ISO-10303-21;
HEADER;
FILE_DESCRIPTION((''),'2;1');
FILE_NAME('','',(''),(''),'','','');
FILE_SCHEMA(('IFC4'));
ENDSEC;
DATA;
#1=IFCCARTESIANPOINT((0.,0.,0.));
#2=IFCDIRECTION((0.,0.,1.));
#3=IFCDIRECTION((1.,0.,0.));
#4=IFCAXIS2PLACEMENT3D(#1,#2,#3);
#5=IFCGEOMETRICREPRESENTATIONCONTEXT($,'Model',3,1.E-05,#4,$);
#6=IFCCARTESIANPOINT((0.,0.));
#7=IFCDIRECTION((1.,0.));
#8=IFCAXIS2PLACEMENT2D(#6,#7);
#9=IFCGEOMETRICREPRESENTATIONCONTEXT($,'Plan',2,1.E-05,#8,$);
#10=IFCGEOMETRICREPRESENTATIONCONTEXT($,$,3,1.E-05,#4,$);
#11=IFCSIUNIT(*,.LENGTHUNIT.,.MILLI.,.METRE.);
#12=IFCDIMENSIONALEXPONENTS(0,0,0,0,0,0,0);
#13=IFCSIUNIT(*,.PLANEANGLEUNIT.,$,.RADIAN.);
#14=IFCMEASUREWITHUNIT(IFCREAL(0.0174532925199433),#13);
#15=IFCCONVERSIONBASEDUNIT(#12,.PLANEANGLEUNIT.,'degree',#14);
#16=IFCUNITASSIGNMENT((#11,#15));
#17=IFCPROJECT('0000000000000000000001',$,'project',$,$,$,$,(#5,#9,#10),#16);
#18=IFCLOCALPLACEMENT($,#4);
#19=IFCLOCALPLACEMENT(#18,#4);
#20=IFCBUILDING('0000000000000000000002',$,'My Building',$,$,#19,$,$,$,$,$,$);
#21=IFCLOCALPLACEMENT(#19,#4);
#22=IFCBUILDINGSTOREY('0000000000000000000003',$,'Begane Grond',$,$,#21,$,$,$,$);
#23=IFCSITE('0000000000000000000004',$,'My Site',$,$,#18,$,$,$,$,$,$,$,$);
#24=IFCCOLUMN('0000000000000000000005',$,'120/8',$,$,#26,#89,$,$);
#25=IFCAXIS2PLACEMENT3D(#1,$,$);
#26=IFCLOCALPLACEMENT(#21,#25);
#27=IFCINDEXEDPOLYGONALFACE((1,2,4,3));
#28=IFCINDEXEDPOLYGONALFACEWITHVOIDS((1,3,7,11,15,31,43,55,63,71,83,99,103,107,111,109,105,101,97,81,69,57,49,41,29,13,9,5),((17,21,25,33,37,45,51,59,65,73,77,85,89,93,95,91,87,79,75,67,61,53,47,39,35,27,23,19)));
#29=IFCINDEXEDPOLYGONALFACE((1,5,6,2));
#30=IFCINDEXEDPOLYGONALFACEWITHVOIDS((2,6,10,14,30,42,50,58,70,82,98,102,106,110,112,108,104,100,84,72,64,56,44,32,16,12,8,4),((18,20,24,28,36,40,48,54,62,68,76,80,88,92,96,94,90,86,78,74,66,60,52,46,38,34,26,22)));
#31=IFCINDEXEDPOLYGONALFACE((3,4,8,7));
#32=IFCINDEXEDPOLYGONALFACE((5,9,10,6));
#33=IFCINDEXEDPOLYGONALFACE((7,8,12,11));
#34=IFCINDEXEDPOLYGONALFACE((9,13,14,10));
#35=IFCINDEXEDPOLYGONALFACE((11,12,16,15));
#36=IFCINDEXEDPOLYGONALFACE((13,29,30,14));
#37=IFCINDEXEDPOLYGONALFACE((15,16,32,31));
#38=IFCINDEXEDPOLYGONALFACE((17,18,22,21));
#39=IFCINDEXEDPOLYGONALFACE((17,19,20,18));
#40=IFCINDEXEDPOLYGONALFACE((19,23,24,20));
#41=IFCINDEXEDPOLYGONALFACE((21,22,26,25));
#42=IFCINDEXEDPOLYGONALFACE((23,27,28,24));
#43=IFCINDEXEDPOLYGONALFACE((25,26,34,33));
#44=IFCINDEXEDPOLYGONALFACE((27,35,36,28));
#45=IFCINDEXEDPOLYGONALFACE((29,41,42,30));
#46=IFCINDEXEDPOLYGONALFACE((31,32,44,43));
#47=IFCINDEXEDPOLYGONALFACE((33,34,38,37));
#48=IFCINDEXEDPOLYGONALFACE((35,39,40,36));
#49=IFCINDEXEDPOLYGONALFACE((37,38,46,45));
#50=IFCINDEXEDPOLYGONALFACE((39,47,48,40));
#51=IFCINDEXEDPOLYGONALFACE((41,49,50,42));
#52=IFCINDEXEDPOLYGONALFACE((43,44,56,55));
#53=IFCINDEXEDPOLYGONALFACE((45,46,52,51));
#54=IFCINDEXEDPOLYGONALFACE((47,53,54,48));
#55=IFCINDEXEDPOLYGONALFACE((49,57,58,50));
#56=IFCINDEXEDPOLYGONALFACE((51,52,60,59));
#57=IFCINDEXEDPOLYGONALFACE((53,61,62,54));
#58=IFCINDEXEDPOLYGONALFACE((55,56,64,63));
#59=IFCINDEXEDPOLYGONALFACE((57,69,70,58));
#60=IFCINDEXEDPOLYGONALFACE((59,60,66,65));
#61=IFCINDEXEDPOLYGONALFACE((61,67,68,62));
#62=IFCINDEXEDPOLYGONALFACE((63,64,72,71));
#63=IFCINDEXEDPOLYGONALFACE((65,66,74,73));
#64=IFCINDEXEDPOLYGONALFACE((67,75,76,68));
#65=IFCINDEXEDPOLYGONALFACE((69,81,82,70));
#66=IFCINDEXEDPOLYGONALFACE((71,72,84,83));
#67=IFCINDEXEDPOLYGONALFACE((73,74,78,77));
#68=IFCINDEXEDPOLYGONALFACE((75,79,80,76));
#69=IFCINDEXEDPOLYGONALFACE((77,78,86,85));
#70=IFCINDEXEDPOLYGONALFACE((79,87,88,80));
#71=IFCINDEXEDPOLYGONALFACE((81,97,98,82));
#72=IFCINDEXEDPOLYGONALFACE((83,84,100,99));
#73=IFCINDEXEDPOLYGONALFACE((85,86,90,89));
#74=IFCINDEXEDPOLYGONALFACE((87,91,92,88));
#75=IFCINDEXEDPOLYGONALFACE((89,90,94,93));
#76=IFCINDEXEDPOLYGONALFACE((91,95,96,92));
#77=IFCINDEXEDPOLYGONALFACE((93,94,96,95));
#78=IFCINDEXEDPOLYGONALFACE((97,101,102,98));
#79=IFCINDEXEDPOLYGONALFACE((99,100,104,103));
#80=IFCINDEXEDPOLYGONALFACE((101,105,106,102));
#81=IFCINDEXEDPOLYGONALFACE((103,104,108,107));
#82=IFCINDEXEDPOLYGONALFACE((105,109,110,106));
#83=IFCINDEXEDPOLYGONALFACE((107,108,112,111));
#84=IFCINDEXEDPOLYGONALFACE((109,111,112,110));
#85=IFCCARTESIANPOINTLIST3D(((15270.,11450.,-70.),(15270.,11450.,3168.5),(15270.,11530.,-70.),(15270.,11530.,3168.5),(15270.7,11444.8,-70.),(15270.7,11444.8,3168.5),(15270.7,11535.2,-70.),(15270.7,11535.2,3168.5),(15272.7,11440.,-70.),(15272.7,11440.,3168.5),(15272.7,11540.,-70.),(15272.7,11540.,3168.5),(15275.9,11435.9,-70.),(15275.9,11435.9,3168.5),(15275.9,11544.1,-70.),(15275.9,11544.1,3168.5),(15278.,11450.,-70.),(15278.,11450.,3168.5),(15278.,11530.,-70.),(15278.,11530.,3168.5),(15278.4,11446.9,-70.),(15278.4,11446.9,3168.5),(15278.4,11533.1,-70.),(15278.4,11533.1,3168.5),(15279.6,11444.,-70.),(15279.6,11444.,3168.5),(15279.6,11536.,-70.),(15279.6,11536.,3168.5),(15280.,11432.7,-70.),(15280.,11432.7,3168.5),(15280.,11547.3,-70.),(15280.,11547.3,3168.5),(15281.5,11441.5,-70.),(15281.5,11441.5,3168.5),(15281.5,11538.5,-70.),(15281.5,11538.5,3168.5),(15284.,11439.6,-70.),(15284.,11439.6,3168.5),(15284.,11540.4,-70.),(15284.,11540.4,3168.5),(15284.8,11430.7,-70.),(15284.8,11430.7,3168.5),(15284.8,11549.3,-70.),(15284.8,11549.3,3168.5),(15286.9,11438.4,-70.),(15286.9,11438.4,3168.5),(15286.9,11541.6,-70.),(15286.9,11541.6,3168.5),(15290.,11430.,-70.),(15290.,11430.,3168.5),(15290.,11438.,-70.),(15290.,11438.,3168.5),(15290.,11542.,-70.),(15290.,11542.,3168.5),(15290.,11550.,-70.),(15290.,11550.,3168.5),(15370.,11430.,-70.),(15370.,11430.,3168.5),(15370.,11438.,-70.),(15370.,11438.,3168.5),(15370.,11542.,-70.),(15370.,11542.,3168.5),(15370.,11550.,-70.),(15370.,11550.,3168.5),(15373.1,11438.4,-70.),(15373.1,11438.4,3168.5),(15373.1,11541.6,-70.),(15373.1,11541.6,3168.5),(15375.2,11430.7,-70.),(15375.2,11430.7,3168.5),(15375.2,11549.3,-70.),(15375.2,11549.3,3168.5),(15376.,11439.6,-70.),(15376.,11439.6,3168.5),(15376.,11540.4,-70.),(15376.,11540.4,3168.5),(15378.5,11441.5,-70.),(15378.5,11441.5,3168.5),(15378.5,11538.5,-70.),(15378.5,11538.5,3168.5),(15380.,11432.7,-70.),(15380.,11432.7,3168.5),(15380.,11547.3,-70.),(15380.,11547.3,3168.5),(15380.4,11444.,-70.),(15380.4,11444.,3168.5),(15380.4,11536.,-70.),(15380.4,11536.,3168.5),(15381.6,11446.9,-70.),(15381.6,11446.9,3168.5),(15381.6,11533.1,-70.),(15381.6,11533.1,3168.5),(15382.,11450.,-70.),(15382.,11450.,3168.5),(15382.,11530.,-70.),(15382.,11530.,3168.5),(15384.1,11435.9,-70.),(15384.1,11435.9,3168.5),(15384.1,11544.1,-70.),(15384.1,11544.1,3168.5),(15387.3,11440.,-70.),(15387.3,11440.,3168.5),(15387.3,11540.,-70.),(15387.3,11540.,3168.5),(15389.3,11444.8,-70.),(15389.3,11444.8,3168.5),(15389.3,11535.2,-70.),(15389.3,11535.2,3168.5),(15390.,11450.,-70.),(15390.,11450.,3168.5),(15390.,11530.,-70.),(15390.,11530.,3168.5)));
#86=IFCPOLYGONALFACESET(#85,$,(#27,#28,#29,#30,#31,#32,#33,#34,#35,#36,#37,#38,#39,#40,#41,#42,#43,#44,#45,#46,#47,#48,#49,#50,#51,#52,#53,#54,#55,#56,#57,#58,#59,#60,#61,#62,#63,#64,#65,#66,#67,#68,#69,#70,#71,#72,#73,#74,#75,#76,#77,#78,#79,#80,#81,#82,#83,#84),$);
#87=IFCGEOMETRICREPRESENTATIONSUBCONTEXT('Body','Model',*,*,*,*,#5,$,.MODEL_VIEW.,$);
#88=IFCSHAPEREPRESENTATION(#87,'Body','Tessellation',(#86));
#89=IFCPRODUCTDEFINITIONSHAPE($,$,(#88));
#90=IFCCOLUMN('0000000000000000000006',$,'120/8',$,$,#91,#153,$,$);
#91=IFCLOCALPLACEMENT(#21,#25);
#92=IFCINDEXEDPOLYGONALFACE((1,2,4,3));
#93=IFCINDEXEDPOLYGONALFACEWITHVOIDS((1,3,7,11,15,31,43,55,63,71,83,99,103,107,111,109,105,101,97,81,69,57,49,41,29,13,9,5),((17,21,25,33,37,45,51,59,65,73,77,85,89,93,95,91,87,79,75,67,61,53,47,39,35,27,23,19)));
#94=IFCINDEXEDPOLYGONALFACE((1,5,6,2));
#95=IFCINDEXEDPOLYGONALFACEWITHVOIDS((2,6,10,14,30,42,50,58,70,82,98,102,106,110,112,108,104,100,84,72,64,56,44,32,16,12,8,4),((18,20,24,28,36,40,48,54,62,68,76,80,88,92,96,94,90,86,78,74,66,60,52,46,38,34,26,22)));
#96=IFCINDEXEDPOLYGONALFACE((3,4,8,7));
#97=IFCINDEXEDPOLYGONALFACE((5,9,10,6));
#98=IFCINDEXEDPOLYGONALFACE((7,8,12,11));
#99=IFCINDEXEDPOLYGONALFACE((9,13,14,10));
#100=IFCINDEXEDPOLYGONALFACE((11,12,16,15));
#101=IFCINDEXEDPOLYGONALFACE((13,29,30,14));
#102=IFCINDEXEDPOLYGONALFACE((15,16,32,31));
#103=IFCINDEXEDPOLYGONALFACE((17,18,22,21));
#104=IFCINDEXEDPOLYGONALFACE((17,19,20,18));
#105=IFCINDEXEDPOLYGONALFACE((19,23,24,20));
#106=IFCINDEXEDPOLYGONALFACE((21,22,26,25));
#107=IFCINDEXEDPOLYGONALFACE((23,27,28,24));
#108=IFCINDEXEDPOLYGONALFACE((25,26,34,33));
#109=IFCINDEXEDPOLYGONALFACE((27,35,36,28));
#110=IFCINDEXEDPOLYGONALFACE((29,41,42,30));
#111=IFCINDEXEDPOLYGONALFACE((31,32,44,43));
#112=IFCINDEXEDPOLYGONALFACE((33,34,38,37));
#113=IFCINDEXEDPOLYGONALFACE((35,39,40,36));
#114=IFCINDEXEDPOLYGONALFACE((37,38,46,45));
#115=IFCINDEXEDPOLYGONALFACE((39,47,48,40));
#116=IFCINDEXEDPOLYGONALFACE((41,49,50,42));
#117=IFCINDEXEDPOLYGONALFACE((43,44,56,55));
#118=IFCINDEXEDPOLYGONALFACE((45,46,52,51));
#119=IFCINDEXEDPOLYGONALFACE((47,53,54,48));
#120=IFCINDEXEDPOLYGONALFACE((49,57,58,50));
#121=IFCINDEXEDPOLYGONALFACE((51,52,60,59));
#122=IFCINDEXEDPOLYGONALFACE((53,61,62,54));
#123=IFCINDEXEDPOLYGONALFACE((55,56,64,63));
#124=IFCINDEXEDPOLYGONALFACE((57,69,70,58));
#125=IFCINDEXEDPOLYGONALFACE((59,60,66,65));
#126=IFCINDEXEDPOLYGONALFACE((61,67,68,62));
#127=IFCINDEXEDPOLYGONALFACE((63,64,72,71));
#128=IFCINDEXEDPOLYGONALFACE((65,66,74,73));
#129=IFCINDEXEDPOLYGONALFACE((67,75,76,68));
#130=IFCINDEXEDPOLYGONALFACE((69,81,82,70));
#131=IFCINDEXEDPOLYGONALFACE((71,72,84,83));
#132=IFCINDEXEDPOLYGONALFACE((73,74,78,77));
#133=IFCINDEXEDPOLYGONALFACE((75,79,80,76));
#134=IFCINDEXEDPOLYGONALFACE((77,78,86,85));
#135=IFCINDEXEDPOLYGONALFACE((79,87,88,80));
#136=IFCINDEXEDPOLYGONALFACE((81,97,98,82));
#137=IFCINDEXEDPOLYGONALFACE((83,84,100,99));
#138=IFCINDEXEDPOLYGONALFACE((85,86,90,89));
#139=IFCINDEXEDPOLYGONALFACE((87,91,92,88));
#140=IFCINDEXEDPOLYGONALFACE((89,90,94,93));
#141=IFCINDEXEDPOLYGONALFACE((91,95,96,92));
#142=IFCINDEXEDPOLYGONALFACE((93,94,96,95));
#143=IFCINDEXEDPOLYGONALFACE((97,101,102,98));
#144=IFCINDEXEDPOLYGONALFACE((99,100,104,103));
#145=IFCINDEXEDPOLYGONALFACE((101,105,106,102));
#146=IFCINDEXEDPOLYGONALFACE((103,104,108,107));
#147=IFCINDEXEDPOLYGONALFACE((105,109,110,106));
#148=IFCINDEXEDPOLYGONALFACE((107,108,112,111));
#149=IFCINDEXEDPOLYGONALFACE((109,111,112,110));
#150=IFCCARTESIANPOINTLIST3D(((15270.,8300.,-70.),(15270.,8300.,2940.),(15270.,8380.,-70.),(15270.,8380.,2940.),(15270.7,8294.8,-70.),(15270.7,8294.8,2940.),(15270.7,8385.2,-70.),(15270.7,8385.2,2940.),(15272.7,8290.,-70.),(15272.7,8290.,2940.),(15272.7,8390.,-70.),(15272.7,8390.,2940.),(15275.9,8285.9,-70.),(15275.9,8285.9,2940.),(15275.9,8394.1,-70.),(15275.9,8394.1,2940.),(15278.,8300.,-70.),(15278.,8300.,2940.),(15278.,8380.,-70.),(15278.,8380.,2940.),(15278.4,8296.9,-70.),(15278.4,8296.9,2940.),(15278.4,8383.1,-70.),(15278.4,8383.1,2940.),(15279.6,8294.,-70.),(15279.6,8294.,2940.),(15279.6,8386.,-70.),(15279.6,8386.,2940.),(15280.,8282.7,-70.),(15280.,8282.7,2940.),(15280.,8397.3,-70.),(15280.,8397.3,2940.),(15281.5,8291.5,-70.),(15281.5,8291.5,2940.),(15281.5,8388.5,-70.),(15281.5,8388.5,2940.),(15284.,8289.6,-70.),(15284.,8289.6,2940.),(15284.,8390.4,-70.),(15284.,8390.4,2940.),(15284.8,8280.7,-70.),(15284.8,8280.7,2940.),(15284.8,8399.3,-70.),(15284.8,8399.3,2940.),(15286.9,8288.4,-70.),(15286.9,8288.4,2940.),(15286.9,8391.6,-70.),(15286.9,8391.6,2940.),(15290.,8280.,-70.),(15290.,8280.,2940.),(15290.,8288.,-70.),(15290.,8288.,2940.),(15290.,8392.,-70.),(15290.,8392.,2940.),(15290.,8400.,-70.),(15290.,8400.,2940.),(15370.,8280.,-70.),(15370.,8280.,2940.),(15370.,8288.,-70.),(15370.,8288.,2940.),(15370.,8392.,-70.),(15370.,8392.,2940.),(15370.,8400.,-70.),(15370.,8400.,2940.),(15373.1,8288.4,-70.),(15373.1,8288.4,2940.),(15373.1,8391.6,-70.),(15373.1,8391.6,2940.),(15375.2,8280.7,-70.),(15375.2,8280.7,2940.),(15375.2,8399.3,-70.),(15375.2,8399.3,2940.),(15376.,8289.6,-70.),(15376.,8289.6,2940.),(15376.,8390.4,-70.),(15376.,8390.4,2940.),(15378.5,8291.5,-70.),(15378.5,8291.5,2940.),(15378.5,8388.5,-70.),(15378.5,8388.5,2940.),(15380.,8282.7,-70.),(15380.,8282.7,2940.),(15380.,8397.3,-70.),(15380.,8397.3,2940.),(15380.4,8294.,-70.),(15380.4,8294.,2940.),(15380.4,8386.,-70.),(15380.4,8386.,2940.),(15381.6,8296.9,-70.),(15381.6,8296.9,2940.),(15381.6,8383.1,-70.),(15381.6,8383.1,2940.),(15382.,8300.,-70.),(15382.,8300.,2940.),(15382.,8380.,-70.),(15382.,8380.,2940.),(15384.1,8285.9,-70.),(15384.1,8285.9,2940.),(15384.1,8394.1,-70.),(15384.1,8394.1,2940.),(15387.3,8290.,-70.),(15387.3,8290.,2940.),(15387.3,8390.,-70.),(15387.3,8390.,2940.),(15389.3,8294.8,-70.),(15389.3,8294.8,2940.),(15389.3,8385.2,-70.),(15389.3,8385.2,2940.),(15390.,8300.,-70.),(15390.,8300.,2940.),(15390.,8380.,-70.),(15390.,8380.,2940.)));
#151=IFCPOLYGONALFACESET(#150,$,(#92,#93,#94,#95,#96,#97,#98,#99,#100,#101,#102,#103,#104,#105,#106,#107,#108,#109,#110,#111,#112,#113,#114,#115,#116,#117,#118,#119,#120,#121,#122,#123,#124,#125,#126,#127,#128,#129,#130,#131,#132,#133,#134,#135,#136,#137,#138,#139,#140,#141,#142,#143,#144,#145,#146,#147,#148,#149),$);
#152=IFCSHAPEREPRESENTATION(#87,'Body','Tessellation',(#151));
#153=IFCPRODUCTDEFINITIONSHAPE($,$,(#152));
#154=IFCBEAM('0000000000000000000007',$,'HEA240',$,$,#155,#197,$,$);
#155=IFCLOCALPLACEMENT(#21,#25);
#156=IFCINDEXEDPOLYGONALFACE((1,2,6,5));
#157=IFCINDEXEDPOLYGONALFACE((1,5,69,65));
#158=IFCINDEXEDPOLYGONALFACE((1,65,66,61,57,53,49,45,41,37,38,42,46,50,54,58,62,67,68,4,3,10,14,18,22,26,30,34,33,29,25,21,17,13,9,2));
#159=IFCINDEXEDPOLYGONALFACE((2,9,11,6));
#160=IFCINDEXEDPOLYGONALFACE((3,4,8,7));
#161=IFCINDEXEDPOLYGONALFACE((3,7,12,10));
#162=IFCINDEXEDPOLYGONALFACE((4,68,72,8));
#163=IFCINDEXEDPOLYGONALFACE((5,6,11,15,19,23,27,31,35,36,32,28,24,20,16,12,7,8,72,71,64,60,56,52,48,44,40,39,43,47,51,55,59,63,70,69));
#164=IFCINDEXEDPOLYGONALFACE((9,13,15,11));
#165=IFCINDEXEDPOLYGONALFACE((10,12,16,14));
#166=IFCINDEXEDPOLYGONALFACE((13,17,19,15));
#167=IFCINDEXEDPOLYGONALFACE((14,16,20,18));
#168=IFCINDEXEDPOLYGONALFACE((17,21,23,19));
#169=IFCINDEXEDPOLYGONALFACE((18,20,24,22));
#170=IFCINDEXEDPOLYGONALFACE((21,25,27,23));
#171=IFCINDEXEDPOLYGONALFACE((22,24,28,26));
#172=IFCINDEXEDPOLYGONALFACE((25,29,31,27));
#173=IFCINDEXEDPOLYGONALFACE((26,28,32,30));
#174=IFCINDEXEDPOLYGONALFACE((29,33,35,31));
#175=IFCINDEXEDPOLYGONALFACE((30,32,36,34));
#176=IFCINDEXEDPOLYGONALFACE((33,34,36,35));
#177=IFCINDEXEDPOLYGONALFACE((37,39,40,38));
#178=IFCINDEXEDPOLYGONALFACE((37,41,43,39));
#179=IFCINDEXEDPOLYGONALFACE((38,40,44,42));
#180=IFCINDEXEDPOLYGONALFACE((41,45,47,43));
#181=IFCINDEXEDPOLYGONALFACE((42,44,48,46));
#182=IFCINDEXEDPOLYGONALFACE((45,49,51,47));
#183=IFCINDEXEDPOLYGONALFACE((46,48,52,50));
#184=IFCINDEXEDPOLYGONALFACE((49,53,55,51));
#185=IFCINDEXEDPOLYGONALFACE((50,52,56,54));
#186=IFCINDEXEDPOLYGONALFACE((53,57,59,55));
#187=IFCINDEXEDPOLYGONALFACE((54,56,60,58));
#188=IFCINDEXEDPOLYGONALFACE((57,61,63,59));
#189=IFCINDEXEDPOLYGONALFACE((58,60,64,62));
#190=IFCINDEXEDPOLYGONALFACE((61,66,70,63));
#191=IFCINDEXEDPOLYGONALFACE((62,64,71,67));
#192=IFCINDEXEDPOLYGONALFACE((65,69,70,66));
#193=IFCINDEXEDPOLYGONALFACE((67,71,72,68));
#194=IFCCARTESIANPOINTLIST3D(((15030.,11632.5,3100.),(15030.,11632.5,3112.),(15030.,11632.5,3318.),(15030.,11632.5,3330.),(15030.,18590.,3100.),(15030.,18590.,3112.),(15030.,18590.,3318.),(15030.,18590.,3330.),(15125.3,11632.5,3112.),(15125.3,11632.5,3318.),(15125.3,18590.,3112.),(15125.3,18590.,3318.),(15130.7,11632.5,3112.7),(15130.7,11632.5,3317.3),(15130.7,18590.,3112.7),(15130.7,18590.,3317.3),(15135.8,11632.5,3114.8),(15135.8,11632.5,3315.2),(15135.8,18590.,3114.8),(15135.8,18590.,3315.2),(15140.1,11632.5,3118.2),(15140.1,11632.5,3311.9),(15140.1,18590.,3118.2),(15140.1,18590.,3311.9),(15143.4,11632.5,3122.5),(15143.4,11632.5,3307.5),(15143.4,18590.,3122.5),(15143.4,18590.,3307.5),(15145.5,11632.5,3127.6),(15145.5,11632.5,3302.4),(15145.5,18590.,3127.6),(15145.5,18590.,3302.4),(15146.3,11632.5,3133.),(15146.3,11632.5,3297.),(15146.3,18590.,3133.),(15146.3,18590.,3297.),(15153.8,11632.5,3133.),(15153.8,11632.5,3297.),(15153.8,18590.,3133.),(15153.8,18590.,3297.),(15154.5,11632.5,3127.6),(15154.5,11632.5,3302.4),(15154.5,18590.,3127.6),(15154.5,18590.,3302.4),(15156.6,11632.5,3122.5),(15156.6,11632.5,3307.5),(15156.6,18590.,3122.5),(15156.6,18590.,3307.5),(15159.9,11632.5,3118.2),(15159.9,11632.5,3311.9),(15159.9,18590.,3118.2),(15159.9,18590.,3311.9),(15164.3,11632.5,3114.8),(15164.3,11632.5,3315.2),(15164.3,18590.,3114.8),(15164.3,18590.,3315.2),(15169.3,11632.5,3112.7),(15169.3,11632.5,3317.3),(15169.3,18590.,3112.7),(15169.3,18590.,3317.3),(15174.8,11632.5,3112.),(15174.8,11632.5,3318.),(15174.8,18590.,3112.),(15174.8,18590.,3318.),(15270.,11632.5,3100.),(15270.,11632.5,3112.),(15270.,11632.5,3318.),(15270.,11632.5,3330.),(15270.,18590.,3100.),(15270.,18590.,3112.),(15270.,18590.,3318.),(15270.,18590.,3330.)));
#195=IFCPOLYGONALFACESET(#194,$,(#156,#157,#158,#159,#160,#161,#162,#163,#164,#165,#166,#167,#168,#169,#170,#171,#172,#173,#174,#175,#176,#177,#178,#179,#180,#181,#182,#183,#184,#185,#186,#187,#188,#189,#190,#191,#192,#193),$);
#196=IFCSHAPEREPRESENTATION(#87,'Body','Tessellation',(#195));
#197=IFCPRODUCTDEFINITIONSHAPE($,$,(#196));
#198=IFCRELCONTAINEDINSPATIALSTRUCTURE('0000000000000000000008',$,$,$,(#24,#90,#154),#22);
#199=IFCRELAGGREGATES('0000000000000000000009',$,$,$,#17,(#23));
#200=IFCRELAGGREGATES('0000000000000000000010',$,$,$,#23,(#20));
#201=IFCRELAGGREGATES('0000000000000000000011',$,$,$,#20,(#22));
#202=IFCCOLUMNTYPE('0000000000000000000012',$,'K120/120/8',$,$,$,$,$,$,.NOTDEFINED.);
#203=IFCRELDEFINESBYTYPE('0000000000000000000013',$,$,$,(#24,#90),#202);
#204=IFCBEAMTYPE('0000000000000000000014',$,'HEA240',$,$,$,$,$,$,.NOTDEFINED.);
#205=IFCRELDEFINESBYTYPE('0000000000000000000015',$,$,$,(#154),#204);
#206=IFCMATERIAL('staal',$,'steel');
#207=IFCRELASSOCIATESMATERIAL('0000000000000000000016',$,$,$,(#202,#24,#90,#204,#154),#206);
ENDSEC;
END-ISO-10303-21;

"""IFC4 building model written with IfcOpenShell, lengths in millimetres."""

from ifc_helpers import new_model, entity, si_unit, converted_unit, frame, origin_with_axes, origin_2d_with_axis, place, context, subcontext, project, spatial, hollow_rectangle, i_section, extrude, material, material_profile, profile_set, profile_usage, type_object, element, save


model = new_model("IFC4")

# Units and contexts
model_context = context("Model", 3, precision=1e-05, world=origin_with_axes())
plan_context = context("Plan", 2, precision=1e-05, world=origin_2d_with_axis())
context_of_model = context(None, 3, precision=1e-05, world=origin_with_axes())
body_context = subcontext(model_context, "Body", "Model", "MODEL_VIEW")
ifc_project = project(units=[si_unit("LENGTHUNIT", "METRE", prefix="MILLI"), converted_unit("PLANEANGLEUNIT", "degree", entity("IfcReal", 0.0174532925199433), si_unit("PLANEANGLEUNIT", "RADIAN"), dimensions=[0, 0, 0, 0, 0, 0, 0])], contexts=[model_context, plan_context, context_of_model])

# Site, building, storey
site_placement = place(None, origin_with_axes())
site = spatial("IfcSite", under=ifc_project, at=site_placement, Name="My Site")
building_placement = place(site_placement, origin_with_axes())
building = spatial("IfcBuilding", under=site, at=building_placement, Name="My Building")
storey_placement = place(building_placement, origin_with_axes())
storey = spatial("IfcBuildingStorey", under=building, at=storey_placement, Name="Begane Grond")

# Columns
ifc_material = material(Name="staal", Category="steel")
ifc_material_profile_1 = material_profile(ifc_material, hollow_rectangle(XDim=120.0, YDim=120.0, WallThickness=8.0, InnerFilletRadius=12.0, OuterFilletRadius=20.0))
ifc_profile_set_1 = profile_set([ifc_material_profile_1], Name="K120/120/8")
ifc_profile_usage_1 = profile_usage(ifc_profile_set_1)
column_type_1 = type_object("IfcColumnType", Name="K120/120/8", PredefinedType="NOTDEFINED", material=ifc_profile_set_1)
column_1_placement = place(storey_placement, frame((15330.0, 11490.0, -70.0), z_axis=(0.0, 0.0, 1.0), x_axis=(1.0, 0.0, 0.0)))
element("IfcColumn", 1, at=column_1_placement, inside=storey, type_object=column_type_1, material=ifc_profile_usage_1, Name="120/8", context=body_context, shape_type="SweptSolid", body=[
    extrude(hollow_rectangle(XDim=120.0, YDim=120.0, WallThickness=8.0, InnerFilletRadius=12.0, OuterFilletRadius=20.0), origin_with_axes(), (0.0, 0.0, 1.0), 3238.5),
])
ifc_profile_usage_2 = profile_usage(ifc_profile_set_1)
column_2_placement = place(storey_placement, frame((15330.0, 8340.0, -70.0), z_axis=(0.0, 0.0, 1.0), x_axis=(1.0, 0.0, 0.0)))
element("IfcColumn", 2, at=column_2_placement, inside=storey, type_object=column_type_1, material=ifc_profile_usage_2, Name="120/8", context=body_context, shape_type="SweptSolid", body=[
    extrude(hollow_rectangle(XDim=120.0, YDim=120.0, WallThickness=8.0, InnerFilletRadius=12.0, OuterFilletRadius=20.0), origin_with_axes(), (0.0, 0.0, 1.0), 3010.0),
])

# Beam
ifc_material_profile_2 = material_profile(ifc_material, i_section(OverallWidth=240.0, OverallDepth=230.0, WebThickness=7.5, FlangeThickness=12.0, FilletRadius=21.0))
ifc_profile_set_2 = profile_set([ifc_material_profile_2], Name="HEA240")
ifc_profile_usage_3 = profile_usage(ifc_profile_set_2, cardinal=5)
beam_type_1 = type_object("IfcBeamType", Name="HEA240", PredefinedType="NOTDEFINED", material=ifc_profile_set_2)
beam_1_placement = place(storey_placement, frame((15150.0, 18590.0, 3215.0), z_axis=(0.0, -1.0, 0.0), x_axis=(1.0, 0.0, 0.0)))
element("IfcBeam", 3, at=beam_1_placement, inside=storey, type_object=beam_type_1, material=ifc_profile_usage_3, Name="HEA240", context=body_context, shape_type="SweptSolid", body=[
    extrude(i_section(OverallWidth=240.0, OverallDepth=230.0, WebThickness=7.5, FlangeThickness=12.0, FilletRadius=21.0), origin_with_axes(), (0.0, 0.0, 1.0), 6957.5),
])

save(model, "model.ifc")
